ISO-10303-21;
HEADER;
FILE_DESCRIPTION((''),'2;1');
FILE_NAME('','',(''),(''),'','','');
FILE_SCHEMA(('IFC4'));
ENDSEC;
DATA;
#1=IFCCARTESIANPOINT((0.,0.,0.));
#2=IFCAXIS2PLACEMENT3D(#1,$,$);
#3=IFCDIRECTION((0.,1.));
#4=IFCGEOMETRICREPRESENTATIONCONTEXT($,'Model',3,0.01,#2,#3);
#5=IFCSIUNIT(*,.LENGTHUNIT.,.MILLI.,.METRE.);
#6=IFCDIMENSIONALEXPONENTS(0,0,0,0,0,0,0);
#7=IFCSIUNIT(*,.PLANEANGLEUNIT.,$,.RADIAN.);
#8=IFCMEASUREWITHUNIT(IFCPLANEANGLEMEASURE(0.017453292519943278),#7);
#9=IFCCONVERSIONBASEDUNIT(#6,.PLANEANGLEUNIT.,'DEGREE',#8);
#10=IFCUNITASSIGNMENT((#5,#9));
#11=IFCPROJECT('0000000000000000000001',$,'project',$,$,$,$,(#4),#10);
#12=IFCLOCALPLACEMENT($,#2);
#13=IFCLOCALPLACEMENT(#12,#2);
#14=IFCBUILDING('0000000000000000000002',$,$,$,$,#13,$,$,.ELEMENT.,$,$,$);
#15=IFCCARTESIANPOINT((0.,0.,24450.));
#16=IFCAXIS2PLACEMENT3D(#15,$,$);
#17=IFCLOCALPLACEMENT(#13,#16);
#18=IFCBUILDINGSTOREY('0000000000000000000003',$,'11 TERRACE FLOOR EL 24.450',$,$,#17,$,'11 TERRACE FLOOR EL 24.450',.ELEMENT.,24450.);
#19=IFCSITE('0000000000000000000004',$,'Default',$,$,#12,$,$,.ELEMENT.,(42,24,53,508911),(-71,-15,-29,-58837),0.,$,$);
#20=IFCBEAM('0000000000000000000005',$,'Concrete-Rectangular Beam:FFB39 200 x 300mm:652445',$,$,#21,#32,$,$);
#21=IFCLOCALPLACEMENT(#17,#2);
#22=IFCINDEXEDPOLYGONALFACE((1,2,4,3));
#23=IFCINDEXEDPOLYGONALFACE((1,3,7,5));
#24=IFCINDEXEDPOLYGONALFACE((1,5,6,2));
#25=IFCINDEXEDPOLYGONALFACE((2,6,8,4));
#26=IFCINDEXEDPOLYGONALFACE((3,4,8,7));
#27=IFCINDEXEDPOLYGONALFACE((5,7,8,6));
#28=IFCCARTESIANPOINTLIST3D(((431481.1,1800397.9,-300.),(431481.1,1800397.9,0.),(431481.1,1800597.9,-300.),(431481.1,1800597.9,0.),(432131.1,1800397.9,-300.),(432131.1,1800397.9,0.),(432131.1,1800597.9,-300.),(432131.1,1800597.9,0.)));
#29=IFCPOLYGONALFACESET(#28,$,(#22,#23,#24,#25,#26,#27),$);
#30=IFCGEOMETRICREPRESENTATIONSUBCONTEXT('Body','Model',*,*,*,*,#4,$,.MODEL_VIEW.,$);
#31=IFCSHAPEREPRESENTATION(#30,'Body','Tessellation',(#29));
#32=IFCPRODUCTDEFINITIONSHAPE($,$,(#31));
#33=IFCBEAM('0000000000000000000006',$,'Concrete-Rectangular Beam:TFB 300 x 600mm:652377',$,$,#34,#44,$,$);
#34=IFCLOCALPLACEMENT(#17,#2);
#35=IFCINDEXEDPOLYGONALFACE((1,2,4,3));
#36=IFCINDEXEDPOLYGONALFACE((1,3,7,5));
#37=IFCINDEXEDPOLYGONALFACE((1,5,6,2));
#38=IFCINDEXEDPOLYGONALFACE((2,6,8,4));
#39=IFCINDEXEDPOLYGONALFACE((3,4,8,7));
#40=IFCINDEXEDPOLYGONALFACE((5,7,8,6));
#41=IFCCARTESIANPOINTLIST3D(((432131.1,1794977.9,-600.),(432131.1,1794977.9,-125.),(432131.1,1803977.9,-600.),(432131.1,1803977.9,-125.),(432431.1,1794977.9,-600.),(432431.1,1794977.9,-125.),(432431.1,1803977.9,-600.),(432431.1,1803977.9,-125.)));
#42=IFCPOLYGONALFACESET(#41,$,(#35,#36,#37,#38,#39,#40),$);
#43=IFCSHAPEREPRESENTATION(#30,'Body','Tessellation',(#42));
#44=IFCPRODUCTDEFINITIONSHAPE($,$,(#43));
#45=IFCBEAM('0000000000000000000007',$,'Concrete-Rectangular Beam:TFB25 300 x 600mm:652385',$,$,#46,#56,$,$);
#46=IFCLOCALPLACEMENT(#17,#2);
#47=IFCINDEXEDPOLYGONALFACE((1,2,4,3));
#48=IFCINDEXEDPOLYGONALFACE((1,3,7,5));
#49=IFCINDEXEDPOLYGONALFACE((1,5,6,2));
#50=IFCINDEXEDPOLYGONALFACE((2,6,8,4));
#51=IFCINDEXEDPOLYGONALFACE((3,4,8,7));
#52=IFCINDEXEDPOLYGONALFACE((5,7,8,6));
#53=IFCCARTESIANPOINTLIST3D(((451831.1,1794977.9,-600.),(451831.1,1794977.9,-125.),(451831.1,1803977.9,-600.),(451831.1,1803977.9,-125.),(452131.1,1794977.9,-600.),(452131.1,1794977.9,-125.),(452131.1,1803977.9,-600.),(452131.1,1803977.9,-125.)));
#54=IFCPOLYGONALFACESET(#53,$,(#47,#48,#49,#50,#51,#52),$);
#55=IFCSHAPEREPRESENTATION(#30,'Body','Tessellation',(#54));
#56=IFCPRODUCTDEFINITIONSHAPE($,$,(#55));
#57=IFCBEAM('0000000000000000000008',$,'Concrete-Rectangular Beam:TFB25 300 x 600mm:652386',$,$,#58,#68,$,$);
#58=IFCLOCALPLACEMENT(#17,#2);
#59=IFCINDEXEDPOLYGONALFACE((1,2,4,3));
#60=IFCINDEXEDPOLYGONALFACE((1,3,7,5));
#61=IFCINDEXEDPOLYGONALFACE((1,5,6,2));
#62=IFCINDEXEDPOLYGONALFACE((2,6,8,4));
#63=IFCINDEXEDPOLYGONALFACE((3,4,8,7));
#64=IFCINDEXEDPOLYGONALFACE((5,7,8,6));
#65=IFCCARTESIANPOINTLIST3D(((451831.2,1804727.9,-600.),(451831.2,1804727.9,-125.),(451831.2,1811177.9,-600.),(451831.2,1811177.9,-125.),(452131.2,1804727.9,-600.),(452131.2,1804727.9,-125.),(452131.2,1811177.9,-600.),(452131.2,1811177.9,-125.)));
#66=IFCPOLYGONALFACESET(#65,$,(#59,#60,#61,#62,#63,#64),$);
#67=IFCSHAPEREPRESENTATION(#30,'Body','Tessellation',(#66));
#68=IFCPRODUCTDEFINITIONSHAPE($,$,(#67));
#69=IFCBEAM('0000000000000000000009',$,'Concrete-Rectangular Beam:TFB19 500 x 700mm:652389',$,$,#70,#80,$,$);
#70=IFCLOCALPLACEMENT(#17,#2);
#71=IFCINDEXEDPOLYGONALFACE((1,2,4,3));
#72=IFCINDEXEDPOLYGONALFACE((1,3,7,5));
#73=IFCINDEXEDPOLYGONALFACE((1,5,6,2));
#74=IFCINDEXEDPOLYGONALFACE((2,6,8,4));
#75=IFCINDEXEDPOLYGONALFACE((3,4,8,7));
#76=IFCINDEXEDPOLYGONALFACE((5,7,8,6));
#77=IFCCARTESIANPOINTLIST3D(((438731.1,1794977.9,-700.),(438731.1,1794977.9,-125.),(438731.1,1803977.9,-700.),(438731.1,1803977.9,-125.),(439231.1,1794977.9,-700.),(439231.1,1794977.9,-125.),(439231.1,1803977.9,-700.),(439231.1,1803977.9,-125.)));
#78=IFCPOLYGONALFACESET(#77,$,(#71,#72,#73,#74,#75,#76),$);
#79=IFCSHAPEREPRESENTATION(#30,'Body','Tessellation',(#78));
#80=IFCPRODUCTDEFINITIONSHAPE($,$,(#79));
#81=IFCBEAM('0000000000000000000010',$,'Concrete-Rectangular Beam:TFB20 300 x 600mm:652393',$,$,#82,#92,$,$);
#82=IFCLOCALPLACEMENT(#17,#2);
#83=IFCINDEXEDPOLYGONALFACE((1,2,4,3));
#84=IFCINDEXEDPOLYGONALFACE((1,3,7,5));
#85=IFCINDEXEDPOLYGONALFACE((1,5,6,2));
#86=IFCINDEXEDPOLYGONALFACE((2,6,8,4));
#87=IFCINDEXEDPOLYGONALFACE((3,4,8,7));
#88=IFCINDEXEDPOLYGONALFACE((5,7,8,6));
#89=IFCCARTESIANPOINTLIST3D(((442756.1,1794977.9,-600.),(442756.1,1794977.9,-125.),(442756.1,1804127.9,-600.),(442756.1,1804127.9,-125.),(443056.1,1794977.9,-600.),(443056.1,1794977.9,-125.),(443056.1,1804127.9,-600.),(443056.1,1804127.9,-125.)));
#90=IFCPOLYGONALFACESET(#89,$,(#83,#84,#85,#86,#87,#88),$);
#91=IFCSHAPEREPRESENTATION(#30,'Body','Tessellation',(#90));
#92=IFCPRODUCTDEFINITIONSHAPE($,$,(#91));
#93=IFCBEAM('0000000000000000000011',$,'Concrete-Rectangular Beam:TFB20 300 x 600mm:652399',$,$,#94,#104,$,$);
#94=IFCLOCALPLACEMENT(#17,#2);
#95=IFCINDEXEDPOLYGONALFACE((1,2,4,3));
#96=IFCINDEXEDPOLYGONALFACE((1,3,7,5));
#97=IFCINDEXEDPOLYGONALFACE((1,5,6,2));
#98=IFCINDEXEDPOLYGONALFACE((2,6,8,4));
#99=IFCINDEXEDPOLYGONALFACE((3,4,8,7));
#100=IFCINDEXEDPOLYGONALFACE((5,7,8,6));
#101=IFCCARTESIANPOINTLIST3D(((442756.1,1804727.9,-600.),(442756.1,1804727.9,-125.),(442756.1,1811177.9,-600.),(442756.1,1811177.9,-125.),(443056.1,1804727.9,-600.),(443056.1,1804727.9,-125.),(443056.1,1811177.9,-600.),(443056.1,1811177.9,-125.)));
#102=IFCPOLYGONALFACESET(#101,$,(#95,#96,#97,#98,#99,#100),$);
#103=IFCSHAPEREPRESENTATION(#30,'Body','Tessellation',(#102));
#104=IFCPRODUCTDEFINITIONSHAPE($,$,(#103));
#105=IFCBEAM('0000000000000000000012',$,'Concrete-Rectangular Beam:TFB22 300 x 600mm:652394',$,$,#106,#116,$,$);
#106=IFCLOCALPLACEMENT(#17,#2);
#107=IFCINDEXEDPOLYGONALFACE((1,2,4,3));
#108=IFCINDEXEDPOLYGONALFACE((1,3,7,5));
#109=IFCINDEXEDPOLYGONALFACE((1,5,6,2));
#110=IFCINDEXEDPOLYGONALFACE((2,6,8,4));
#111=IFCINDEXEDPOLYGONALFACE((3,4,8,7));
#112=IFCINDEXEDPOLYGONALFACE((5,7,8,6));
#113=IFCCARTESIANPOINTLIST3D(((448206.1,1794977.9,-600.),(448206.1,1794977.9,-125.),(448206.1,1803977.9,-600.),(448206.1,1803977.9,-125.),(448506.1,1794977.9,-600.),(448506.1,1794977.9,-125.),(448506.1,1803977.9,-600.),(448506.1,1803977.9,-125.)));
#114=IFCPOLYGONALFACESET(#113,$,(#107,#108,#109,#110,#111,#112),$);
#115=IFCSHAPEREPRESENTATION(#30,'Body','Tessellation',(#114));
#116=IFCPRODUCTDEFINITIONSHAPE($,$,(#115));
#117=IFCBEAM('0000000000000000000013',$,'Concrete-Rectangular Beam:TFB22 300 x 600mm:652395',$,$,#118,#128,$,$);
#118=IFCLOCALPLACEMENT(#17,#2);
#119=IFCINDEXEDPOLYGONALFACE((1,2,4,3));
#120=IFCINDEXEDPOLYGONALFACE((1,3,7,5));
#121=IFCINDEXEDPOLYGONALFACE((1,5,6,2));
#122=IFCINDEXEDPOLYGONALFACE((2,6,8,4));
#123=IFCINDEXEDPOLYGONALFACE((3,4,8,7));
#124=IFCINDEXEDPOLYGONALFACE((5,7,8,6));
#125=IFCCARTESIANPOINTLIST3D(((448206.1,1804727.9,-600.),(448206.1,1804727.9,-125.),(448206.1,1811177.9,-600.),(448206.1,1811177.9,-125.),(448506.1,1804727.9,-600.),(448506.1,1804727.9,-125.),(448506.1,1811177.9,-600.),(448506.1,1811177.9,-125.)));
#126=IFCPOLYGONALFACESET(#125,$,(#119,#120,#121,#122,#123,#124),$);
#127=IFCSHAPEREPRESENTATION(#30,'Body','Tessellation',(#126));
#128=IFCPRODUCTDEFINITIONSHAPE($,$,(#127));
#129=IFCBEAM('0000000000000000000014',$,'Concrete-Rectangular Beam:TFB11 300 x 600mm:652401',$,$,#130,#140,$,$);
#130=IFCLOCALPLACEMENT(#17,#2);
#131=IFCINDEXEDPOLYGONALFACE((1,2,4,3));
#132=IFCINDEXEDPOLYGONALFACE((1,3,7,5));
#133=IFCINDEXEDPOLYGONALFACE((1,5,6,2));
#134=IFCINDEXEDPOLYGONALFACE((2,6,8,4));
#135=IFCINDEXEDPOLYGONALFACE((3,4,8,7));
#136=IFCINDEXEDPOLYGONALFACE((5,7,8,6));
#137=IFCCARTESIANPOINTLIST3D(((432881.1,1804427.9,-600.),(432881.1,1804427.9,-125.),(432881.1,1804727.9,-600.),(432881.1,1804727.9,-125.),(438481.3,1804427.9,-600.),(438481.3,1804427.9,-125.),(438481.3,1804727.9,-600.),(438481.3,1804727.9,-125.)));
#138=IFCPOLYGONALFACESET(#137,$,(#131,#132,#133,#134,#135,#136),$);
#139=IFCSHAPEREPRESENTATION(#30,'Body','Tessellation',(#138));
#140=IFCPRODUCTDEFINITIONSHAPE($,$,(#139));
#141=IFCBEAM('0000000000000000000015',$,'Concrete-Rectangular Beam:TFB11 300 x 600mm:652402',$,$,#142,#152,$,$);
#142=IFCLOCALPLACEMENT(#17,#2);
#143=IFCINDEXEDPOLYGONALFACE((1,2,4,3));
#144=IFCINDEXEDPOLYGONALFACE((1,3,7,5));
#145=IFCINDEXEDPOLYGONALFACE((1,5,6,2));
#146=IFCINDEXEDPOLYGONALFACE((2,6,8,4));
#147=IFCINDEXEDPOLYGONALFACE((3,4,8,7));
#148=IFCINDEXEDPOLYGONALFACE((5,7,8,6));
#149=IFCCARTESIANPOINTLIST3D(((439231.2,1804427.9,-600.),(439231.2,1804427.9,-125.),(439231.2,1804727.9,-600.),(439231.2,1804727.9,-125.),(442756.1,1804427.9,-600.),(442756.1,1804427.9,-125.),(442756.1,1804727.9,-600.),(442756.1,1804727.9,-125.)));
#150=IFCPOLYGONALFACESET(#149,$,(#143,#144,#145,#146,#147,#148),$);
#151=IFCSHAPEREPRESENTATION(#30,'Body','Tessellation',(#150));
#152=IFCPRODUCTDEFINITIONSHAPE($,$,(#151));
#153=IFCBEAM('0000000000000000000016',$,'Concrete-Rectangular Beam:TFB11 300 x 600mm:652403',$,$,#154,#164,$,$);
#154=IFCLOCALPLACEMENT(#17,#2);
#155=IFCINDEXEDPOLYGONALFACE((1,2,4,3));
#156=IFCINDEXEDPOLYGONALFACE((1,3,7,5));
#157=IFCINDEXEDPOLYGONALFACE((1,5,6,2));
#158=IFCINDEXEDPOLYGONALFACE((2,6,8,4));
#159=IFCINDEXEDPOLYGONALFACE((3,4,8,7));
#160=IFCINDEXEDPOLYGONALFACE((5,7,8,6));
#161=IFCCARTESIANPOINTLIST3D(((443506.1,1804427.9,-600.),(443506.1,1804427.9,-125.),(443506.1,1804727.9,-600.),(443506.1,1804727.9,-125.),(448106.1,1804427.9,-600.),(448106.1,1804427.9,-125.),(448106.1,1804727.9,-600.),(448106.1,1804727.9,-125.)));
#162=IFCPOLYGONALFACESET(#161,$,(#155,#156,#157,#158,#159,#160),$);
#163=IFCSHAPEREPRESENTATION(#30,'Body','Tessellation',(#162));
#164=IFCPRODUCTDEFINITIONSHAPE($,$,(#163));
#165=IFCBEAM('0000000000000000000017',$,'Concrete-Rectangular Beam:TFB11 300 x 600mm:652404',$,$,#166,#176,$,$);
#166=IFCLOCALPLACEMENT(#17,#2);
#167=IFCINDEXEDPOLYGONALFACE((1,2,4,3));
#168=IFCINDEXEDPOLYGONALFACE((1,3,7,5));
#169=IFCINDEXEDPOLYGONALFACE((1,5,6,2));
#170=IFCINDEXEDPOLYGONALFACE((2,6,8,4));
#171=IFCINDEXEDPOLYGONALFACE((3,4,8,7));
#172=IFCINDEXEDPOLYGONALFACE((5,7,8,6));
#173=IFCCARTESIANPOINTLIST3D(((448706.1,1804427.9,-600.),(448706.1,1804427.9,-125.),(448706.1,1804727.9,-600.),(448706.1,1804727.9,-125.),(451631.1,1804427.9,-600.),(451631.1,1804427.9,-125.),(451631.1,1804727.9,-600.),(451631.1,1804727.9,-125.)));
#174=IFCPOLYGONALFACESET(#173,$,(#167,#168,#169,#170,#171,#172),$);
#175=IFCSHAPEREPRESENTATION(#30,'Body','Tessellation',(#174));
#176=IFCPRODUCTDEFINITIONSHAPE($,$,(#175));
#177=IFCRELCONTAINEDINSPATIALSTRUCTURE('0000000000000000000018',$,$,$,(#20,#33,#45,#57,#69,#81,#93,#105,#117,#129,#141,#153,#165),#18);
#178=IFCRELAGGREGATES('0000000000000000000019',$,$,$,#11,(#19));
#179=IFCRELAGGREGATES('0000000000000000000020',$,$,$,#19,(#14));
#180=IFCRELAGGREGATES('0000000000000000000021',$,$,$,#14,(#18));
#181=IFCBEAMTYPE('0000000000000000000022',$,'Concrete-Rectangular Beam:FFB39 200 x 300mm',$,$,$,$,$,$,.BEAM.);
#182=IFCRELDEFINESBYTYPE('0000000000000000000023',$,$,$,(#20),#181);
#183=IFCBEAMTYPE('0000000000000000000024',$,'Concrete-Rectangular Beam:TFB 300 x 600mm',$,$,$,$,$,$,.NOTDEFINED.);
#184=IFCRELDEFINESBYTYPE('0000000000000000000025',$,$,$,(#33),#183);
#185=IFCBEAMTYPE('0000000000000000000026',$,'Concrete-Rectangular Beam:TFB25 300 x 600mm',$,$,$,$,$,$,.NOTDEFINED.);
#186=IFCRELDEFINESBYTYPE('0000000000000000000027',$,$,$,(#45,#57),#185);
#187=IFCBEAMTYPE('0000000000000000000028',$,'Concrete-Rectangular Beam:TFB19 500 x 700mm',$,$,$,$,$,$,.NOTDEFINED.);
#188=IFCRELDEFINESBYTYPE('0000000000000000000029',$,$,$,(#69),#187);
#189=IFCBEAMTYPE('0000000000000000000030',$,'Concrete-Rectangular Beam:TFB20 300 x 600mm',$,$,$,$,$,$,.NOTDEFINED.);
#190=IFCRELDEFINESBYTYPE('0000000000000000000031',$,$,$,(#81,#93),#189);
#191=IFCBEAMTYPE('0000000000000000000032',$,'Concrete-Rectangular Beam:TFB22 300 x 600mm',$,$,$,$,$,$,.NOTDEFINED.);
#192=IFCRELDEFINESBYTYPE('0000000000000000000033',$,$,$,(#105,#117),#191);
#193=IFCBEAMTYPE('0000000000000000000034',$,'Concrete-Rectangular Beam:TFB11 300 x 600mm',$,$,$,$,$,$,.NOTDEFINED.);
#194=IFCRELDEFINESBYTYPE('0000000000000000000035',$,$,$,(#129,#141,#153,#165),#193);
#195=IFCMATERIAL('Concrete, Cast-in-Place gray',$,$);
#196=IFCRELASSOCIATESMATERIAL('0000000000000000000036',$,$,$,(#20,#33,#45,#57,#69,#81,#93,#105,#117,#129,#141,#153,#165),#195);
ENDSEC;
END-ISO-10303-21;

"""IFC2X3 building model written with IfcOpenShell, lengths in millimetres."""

from ifc_helpers import new_model, entity, si_unit, converted_unit, direction, frame, frame_2d, origin, origin_2d_with_axis, place, context, subcontext, project, spatial, rectangle, extrude, material, type_object, element, save


model = new_model("IFC2X3")

# Units and contexts
model_context = context("Model", 3, precision=0.01, world=origin(), true_north=direction((0.0, 1.0)))
body_context = subcontext(model_context, "Body", "Model", "MODEL_VIEW")
ifc_project = project(units=[si_unit("LENGTHUNIT", "METRE", prefix="MILLI"), converted_unit("PLANEANGLEUNIT", "DEGREE", entity("IfcPlaneAngleMeasure", 0.017453292519943278), si_unit("PLANEANGLEUNIT", "RADIAN"), dimensions=[0, 0, 0, 0, 0, 0, 0])], contexts=[model_context])

# Site, building, storey
site_placement = place(None, origin())
site = spatial("IfcSite", under=ifc_project, at=site_placement, Name="Default", CompositionType="ELEMENT", RefLatitude=(42, 24, 53, 508911), RefLongitude=(-71, -15, -29, -58837), RefElevation=0.0)
building_placement = place(site_placement, origin())
building = spatial("IfcBuilding", under=site, at=building_placement, CompositionType="ELEMENT")
storey_placement = place(building_placement, frame((0.0, 0.0, 24450.0)))
storey = spatial("IfcBuildingStorey", under=building, at=storey_placement, Name="11 TERRACE FLOOR EL 24.450", LongName="11 TERRACE FLOOR EL 24.450", CompositionType="ELEMENT", Elevation=24450.0)

# Beams
ifc_material = material(Name="Concrete, Cast-in-Place gray")
beam_type_1 = type_object("IfcBeamType", Name="Concrete-Rectangular Beam:FFB39 200 x 300mm", PredefinedType="BEAM")
beam_1_placement = place(storey_placement, frame((431681.1, 1800597.9, 0.0)))
element("IfcBeam", 1, at=beam_1_placement, inside=storey, type_object=beam_type_1, material=ifc_material, Name="Concrete-Rectangular Beam:FFB39 200 x 300mm:652445", context=body_context, shape_type="SweptSolid", body=[
    extrude(rectangle(XDim=300.0, YDim=200.0, at=origin_2d_with_axis()), frame((-200.0, -100.0, -150.0), z_axis=(1.0, 0.0, 0.0), x_axis=(0.0, 0.0, -1.0)), (0.0, 0.0, 1.0), 650.0),
])
beam_type_2 = type_object("IfcBeamType", Name="Concrete-Rectangular Beam:TFB 300 x 600mm", PredefinedType="NOTDEFINED")
beam_2_placement = place(storey_placement, frame((432431.1, 1794977.9, 0.0), z_axis=(0.0, 0.0, 1.0), x_axis=(0.0, 1.0, 0.0)))
element("IfcBeam", 2, at=beam_2_placement, inside=storey, type_object=beam_type_2, material=ifc_material, Name="Concrete-Rectangular Beam:TFB 300 x 600mm:652377", context=body_context, shape_type="SweptSolid", body=[
    extrude(rectangle(XDim=475.0, YDim=300.0, at=frame_2d((0.0, 0.0), x_axis=(1.0, 0.0))), frame((0.0, 150.0, -362.5), z_axis=(1.0, 0.0, 0.0), x_axis=(0.0, 0.0, -1.0)), (0.0, 0.0, 1.0), 9000.0),
])
beam_type_3 = type_object("IfcBeamType", Name="Concrete-Rectangular Beam:TFB25 300 x 600mm", PredefinedType="NOTDEFINED")
beam_3_placement = place(storey_placement, frame((451831.1, 1794962.9, 0.0), z_axis=(0.0, 0.0, 1.0), x_axis=(0.0, 1.0, 0.0)))
element("IfcBeam", 3, at=beam_3_placement, inside=storey, type_object=beam_type_3, material=ifc_material, Name="Concrete-Rectangular Beam:TFB25 300 x 600mm:652385", context=body_context, shape_type="SweptSolid", body=[
    extrude(rectangle(XDim=475.0, YDim=300.0, at=frame_2d((0.0, 0.0), x_axis=(1.0, 0.0))), frame((15.0, -150.0, -362.5), z_axis=(1.0, 0.0, 0.0), x_axis=(0.0, 0.0, -1.0)), (0.0, 0.0, 1.0), 9000.0),
])
beam_4_placement = place(storey_placement, frame((451831.2, 1804727.9, 0.0), z_axis=(0.0, 0.0, 1.0), x_axis=(0.0, 1.0, 0.0)))
element("IfcBeam", 4, at=beam_4_placement, inside=storey, type_object=beam_type_3, material=ifc_material, Name="Concrete-Rectangular Beam:TFB25 300 x 600mm:652386", context=body_context, shape_type="SweptSolid", body=[
    extrude(rectangle(XDim=475.0, YDim=300.0, at=frame_2d((0.0, 0.0), x_axis=(1.0, 0.0))), frame((0.0, -150.0, -362.5), z_axis=(1.0, 0.0, 0.0), x_axis=(0.0, 0.0, -1.0)), (0.0, 0.0, 1.0), 6450.0),
])
beam_type_4 = type_object("IfcBeamType", Name="Concrete-Rectangular Beam:TFB19 500 x 700mm", PredefinedType="NOTDEFINED")
beam_5_placement = place(storey_placement, frame((438731.1, 1794977.9, 0.0), z_axis=(0.0, 0.0, 1.0), x_axis=(0.0, 1.0, 0.0)))
element("IfcBeam", 5, at=beam_5_placement, inside=storey, type_object=beam_type_4, material=ifc_material, Name="Concrete-Rectangular Beam:TFB19 500 x 700mm:652389", context=body_context, shape_type="SweptSolid", body=[
    extrude(rectangle(XDim=575.0, YDim=500.0, at=frame_2d((0.0, 0.0), x_axis=(1.0, 0.0))), frame((0.0, -250.0, -412.5), z_axis=(1.0, 0.0, 0.0), x_axis=(0.0, 0.0, -1.0)), (0.0, 0.0, 1.0), 9000.0),
])
beam_type_5 = type_object("IfcBeamType", Name="Concrete-Rectangular Beam:TFB20 300 x 600mm", PredefinedType="NOTDEFINED")
beam_6_placement = place(storey_placement, frame((442756.1, 1794977.5, 0.0), z_axis=(0.0, 0.0, 1.0), x_axis=(0.0, 1.0, 0.0)))
element("IfcBeam", 6, at=beam_6_placement, inside=storey, type_object=beam_type_5, material=ifc_material, Name="Concrete-Rectangular Beam:TFB20 300 x 600mm:652393", context=body_context, shape_type="SweptSolid", body=[
    extrude(rectangle(XDim=475.0, YDim=300.0, at=frame_2d((0.0, 0.0), x_axis=(1.0, 0.0))), frame((0.4, -150.0, -362.5), z_axis=(1.0, 0.0, 0.0), x_axis=(0.0, 0.0, -1.0)), (0.0, 0.0, 1.0), 9150.0),
])
beam_7_placement = place(storey_placement, frame((442756.1, 1804727.9, 0.0), z_axis=(0.0, 0.0, 1.0), x_axis=(0.0, 1.0, 0.0)))
element("IfcBeam", 7, at=beam_7_placement, inside=storey, type_object=beam_type_5, material=ifc_material, Name="Concrete-Rectangular Beam:TFB20 300 x 600mm:652399", context=body_context, shape_type="SweptSolid", body=[
    extrude(rectangle(XDim=475.0, YDim=300.0, at=frame_2d((0.0, 0.0), x_axis=(1.0, 0.0))), frame((0.0, -150.0, -362.5), z_axis=(1.0, 0.0, 0.0), x_axis=(0.0, 0.0, -1.0)), (0.0, 0.0, 1.0), 6450.0),
])
beam_type_6 = type_object("IfcBeamType", Name="Concrete-Rectangular Beam:TFB22 300 x 600mm", PredefinedType="NOTDEFINED")
beam_8_placement = place(storey_placement, frame((448206.1, 1794977.9, 0.0), z_axis=(0.0, 0.0, 1.0), x_axis=(0.0, 1.0, 0.0)))
element("IfcBeam", 8, at=beam_8_placement, inside=storey, type_object=beam_type_6, material=ifc_material, Name="Concrete-Rectangular Beam:TFB22 300 x 600mm:652394", context=body_context, shape_type="SweptSolid", body=[
    extrude(rectangle(XDim=475.0, YDim=300.0, at=frame_2d((0.0, 0.0), x_axis=(1.0, 0.0))), frame((0.0, -150.0, -362.5), z_axis=(1.0, 0.0, 0.0), x_axis=(0.0, 0.0, -1.0)), (0.0, 0.0, 1.0), 9000.0),
])
beam_9_placement = place(storey_placement, frame((448206.1, 1804727.9, 0.0), z_axis=(0.0, 0.0, 1.0), x_axis=(0.0, 1.0, 0.0)))
element("IfcBeam", 9, at=beam_9_placement, inside=storey, type_object=beam_type_6, material=ifc_material, Name="Concrete-Rectangular Beam:TFB22 300 x 600mm:652395", context=body_context, shape_type="SweptSolid", body=[
    extrude(rectangle(XDim=475.0, YDim=300.0, at=frame_2d((0.0, 0.0), x_axis=(1.0, 0.0))), frame((0.0, -150.0, -362.5), z_axis=(1.0, 0.0, 0.0), x_axis=(0.0, 0.0, -1.0)), (0.0, 0.0, 1.0), 6450.0),
])
beam_type_7 = type_object("IfcBeamType", Name="Concrete-Rectangular Beam:TFB11 300 x 600mm", PredefinedType="NOTDEFINED")
beam_10_placement = place(storey_placement, frame((432881.1, 1804727.9, 0.0)))
element("IfcBeam", 10, at=beam_10_placement, inside=storey, type_object=beam_type_7, material=ifc_material, Name="Concrete-Rectangular Beam:TFB11 300 x 600mm:652401", context=body_context, shape_type="SweptSolid", body=[
    extrude(rectangle(XDim=475.0, YDim=300.0, at=frame_2d((0.0, 0.0), x_axis=(1.0, 0.0))), frame((0.0, -150.0, -362.5), z_axis=(1.0, 0.0, 0.0), x_axis=(0.0, 0.0, -1.0)), (0.0, 0.0, 1.0), 5600.2),
])
beam_11_placement = place(storey_placement, frame((439231.2, 1804727.9, 0.0)))
element("IfcBeam", 11, at=beam_11_placement, inside=storey, type_object=beam_type_7, material=ifc_material, Name="Concrete-Rectangular Beam:TFB11 300 x 600mm:652402", context=body_context, shape_type="SweptSolid", body=[
    extrude(rectangle(XDim=475.0, YDim=300.0, at=frame_2d((0.0, 0.0), x_axis=(1.0, 0.0))), frame((0.0, -150.0, -362.5), z_axis=(1.0, 0.0, 0.0), x_axis=(0.0, 0.0, -1.0)), (0.0, 0.0, 1.0), 3524.9),
])
beam_12_placement = place(storey_placement, frame((443506.1, 1804727.9, 0.0)))
element("IfcBeam", 12, at=beam_12_placement, inside=storey, type_object=beam_type_7, material=ifc_material, Name="Concrete-Rectangular Beam:TFB11 300 x 600mm:652403", context=body_context, shape_type="SweptSolid", body=[
    extrude(rectangle(XDim=475.0, YDim=300.0, at=frame_2d((0.0, 0.0), x_axis=(1.0, 0.0))), frame((0.0, -150.0, -362.5), z_axis=(1.0, 0.0, 0.0), x_axis=(0.0, 0.0, -1.0)), (0.0, 0.0, 1.0), 4600.0),
])
beam_13_placement = place(storey_placement, frame((448706.1, 1804727.9, 0.0)))
element("IfcBeam", 13, at=beam_13_placement, inside=storey, type_object=beam_type_7, material=ifc_material, Name="Concrete-Rectangular Beam:TFB11 300 x 600mm:652404", context=body_context, shape_type="SweptSolid", body=[
    extrude(rectangle(XDim=475.0, YDim=300.0, at=frame_2d((0.0, 0.0), x_axis=(1.0, 0.0))), frame((0.0, -150.0, -362.5), z_axis=(1.0, 0.0, 0.0), x_axis=(0.0, 0.0, -1.0)), (0.0, 0.0, 1.0), 2925.0),
])

save(model, "model.ifc")
